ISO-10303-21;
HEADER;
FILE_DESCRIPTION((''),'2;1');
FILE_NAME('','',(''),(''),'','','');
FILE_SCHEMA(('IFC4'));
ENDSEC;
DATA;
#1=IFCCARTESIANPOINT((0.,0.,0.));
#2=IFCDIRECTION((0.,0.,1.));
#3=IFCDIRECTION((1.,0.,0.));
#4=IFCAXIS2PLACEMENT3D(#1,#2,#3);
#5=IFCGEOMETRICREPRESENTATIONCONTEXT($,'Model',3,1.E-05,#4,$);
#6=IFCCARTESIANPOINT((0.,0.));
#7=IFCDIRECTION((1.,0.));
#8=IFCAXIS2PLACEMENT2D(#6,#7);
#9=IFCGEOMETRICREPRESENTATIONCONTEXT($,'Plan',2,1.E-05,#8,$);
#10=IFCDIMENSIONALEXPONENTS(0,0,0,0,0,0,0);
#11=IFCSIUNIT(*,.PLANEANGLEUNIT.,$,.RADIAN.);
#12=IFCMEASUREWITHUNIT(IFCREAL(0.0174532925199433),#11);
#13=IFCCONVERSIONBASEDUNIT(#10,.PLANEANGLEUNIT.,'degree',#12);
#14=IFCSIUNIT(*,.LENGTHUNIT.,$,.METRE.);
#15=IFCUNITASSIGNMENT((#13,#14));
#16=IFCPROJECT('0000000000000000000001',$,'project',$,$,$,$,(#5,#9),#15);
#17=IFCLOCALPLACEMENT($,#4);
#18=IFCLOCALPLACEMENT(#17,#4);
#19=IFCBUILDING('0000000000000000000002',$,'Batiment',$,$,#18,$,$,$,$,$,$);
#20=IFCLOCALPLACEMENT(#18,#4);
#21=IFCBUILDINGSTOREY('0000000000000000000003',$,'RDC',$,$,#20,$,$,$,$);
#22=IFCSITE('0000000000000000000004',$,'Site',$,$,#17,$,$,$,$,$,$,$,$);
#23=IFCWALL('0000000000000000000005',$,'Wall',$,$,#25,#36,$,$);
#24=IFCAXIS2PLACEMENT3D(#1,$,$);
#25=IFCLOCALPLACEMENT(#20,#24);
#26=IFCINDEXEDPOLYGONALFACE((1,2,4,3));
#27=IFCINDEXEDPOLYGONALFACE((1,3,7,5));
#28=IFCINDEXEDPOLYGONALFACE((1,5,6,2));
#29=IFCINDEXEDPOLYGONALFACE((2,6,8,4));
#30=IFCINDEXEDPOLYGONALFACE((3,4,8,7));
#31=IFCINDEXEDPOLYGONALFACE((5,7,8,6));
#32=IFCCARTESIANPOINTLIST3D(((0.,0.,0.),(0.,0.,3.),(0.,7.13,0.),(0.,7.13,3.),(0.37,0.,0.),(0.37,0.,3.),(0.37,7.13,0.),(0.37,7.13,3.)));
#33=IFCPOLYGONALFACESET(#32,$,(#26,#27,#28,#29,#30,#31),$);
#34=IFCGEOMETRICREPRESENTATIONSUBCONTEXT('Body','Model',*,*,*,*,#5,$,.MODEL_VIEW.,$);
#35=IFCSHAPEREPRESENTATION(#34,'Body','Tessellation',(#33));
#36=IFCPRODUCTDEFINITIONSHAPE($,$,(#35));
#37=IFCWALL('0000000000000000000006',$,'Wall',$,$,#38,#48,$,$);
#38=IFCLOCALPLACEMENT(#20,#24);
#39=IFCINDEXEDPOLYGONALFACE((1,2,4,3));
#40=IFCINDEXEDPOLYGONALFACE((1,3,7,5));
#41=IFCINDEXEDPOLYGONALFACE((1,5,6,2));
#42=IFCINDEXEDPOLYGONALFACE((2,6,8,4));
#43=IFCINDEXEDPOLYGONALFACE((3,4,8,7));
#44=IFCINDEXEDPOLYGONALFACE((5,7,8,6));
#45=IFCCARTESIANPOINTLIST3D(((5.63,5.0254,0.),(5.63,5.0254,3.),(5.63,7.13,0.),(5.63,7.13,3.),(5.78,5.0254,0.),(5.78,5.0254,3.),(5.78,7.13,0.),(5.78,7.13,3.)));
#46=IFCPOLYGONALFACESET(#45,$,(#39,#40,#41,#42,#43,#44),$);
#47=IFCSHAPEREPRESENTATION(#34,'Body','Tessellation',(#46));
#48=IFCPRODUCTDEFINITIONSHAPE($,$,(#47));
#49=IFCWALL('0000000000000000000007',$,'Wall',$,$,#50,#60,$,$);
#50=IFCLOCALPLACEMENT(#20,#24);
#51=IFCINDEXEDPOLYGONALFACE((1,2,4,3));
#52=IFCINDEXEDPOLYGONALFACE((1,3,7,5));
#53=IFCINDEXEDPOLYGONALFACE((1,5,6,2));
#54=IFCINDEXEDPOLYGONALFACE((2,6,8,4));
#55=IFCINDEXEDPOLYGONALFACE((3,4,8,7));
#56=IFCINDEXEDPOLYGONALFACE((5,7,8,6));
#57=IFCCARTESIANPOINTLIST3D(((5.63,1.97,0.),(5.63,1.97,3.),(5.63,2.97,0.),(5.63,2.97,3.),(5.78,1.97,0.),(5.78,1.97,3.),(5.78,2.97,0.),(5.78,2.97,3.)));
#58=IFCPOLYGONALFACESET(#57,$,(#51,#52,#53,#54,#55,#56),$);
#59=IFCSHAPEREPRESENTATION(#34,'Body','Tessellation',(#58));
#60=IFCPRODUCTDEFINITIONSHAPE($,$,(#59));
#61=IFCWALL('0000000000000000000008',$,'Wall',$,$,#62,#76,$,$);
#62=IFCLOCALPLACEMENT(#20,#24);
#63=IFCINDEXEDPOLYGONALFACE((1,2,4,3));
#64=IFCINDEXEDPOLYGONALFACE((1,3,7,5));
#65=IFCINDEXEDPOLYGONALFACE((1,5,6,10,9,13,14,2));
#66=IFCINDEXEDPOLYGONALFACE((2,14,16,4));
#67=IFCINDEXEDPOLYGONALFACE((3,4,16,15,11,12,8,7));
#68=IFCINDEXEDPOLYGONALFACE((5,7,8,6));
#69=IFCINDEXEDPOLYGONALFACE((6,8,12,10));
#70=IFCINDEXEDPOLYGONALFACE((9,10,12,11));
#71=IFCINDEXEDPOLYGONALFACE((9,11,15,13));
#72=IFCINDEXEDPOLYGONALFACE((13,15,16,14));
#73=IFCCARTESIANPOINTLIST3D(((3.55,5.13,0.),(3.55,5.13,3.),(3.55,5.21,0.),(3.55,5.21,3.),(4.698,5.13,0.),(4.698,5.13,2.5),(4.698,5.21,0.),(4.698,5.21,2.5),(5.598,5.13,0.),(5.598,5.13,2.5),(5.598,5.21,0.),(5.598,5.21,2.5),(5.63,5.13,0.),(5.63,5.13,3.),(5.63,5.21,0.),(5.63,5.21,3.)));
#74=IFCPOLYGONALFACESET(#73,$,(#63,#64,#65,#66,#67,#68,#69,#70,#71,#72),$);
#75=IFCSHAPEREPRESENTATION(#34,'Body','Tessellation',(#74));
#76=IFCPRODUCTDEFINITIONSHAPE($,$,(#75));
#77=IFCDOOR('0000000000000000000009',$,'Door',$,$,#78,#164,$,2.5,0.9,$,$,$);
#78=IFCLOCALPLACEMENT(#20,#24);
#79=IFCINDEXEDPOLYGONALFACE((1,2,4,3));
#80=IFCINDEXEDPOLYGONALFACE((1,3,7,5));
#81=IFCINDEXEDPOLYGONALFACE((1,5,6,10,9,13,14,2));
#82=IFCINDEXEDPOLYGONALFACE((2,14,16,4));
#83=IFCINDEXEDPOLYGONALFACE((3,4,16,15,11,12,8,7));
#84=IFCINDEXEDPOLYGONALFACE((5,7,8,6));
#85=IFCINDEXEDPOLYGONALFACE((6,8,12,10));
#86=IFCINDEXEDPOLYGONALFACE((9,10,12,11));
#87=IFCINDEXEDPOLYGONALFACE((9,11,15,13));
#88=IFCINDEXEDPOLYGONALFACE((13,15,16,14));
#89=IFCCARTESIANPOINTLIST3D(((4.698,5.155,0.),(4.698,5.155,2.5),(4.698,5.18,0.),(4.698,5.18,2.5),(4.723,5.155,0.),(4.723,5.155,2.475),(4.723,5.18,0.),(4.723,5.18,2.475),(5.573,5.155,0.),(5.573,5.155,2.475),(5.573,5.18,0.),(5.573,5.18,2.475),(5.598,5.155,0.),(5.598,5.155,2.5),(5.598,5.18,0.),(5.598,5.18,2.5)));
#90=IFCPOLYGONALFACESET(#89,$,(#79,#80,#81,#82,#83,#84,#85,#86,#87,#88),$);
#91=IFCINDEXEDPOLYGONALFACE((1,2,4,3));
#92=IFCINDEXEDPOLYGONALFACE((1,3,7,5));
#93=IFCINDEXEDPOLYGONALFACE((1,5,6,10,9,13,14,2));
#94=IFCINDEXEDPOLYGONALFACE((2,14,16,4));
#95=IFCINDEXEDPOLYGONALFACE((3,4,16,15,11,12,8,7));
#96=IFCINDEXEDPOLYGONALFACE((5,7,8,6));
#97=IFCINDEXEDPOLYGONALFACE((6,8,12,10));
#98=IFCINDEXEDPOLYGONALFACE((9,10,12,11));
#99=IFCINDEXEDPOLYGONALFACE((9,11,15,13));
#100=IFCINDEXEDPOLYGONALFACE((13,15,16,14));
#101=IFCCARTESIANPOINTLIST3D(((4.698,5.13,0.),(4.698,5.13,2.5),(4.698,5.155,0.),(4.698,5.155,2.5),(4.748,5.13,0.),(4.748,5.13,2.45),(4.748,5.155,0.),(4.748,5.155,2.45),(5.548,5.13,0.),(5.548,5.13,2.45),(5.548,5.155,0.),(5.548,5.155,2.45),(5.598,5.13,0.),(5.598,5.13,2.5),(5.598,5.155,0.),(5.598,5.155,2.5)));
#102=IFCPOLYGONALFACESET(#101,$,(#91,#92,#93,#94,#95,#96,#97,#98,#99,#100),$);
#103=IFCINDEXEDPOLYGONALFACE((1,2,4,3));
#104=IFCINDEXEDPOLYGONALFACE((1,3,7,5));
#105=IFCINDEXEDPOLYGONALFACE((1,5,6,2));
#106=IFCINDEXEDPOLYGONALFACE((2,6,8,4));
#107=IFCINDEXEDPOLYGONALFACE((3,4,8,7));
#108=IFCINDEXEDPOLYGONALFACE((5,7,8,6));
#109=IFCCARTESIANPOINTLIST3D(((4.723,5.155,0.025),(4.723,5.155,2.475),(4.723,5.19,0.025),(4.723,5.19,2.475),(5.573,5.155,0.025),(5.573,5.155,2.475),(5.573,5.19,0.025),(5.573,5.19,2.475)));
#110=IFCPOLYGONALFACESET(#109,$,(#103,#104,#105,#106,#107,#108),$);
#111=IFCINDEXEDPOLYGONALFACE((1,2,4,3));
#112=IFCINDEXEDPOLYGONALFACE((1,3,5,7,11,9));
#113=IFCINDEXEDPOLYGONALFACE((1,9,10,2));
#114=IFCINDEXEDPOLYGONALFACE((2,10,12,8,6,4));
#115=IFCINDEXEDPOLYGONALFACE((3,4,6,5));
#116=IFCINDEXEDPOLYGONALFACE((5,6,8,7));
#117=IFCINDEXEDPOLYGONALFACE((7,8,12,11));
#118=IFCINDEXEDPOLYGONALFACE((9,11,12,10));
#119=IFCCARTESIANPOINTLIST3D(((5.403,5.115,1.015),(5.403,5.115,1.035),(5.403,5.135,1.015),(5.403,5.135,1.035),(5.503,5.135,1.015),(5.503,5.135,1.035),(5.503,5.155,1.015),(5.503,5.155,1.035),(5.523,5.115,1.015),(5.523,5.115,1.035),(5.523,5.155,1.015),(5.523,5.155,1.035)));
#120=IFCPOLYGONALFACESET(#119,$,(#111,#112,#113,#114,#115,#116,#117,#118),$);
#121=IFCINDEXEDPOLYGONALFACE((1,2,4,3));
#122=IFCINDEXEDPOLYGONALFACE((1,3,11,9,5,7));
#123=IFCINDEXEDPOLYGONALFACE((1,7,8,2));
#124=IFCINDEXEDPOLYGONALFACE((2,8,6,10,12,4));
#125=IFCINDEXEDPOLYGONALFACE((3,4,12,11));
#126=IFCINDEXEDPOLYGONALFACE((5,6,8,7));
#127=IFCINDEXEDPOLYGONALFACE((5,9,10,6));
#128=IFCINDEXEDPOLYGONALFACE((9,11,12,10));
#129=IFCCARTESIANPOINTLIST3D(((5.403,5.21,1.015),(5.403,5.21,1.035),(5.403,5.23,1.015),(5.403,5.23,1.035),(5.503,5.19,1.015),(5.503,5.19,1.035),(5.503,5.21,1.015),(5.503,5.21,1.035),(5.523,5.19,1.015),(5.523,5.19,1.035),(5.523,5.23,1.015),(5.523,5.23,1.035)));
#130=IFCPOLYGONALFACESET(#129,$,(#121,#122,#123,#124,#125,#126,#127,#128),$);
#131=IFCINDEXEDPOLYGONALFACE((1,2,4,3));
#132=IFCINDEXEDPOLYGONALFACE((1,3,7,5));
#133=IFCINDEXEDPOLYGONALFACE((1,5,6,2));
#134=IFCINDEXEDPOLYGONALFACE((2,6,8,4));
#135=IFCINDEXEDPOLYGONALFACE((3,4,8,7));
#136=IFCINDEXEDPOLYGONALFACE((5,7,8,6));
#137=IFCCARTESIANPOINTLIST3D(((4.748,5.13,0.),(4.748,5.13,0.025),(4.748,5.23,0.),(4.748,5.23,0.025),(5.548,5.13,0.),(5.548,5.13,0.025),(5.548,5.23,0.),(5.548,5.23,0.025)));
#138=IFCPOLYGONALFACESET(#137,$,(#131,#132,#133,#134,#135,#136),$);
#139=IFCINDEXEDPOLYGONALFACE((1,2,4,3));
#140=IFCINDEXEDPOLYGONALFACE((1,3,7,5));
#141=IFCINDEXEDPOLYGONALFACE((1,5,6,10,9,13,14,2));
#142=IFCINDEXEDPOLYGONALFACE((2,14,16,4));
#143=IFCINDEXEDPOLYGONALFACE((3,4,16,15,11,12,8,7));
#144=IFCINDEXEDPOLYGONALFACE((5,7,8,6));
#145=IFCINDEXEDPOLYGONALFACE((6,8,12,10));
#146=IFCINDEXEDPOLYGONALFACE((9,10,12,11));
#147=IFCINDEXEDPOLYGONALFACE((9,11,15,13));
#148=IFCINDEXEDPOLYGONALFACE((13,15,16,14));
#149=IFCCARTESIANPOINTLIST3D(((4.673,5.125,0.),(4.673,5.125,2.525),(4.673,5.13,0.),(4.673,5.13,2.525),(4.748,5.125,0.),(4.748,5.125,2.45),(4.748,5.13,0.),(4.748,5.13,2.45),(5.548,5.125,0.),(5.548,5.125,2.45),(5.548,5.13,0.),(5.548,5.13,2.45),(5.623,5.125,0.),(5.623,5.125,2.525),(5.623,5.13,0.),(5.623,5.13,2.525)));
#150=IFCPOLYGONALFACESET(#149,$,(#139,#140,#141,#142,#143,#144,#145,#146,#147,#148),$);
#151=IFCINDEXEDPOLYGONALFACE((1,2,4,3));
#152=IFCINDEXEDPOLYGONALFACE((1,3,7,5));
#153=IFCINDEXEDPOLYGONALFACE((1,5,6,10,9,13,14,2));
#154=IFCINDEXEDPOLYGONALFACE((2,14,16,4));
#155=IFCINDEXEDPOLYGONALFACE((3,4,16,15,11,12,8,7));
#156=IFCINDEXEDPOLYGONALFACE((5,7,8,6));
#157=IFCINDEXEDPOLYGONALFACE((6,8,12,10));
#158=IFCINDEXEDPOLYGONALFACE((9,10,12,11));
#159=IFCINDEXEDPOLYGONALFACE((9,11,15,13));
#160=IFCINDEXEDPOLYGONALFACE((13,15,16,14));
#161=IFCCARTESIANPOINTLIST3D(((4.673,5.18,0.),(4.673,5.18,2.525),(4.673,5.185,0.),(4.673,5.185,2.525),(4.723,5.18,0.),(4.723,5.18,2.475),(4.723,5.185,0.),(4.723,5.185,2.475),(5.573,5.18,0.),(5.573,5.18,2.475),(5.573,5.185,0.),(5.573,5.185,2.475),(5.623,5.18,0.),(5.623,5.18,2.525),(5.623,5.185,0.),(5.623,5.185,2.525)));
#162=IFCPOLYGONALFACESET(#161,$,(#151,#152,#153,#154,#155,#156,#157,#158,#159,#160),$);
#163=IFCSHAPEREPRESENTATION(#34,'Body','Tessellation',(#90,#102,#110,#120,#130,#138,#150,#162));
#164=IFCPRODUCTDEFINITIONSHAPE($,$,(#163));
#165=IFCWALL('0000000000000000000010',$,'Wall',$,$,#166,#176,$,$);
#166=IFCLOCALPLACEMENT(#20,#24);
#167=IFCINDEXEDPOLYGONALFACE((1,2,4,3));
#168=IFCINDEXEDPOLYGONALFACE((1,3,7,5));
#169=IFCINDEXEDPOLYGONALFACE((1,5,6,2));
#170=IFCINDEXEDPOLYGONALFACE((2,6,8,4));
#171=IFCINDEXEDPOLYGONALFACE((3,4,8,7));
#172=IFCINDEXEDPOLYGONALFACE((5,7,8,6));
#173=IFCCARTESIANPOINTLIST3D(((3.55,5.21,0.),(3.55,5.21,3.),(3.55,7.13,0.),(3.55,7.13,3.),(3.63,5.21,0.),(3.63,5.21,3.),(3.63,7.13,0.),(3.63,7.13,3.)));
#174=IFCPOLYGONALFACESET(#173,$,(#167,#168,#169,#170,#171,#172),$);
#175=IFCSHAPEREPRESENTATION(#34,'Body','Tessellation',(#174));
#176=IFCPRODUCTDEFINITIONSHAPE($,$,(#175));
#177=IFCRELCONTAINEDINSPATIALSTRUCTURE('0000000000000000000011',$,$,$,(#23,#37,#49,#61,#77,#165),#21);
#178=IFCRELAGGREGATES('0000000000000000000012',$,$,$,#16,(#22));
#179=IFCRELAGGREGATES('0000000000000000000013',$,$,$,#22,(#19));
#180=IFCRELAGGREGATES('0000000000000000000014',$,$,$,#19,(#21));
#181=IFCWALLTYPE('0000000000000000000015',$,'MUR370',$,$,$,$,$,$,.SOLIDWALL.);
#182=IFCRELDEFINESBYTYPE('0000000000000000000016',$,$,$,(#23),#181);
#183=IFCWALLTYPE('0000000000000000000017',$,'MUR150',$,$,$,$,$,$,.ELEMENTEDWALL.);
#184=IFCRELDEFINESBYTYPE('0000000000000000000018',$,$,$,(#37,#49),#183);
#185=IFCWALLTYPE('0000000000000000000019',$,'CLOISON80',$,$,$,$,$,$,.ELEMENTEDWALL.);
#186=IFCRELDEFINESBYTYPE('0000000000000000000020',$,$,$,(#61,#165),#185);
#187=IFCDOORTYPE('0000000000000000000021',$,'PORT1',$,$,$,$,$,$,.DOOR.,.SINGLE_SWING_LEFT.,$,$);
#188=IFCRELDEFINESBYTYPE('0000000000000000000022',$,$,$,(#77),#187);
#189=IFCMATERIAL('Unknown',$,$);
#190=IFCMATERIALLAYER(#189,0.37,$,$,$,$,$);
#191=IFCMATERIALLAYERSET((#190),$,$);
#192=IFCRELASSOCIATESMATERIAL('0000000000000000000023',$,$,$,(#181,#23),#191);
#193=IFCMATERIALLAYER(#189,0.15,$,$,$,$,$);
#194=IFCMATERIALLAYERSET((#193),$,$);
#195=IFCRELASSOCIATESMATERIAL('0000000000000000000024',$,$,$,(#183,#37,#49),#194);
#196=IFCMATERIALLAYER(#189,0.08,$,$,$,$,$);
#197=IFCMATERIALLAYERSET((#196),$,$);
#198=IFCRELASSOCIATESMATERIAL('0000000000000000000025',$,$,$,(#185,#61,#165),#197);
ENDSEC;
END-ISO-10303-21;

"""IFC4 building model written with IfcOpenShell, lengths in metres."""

from ifc_helpers import new_model, entity, si_unit, converted_unit, frame, origin_with_axes, origin_2d_with_axis, place, context, subcontext, project, spatial, line, indexed_curve, outline, extrude, shape, source, transform, mapped, material, layer, layer_set, layer_usage, type_object, type_shapes, element, fill, save


model = new_model("IFC4")

# Units and contexts
model_context = context("Model", 3, precision=1e-05, world=origin_with_axes())
plan_context = context("Plan", 2, precision=1e-05, world=origin_2d_with_axis())
body_context_1 = subcontext(model_context, "Body", "Model", "MODEL_VIEW")
body_context_2 = subcontext(plan_context, "Body", "Plan", "PLAN_VIEW")
ifc_project = project(units=[converted_unit("PLANEANGLEUNIT", "degree", entity("IfcReal", 0.0174532925199433), si_unit("PLANEANGLEUNIT", "RADIAN"), dimensions=[0, 0, 0, 0, 0, 0, 0]), si_unit("LENGTHUNIT", "METRE")], contexts=[model_context, plan_context])

# Site, building, storey
site_placement = place(None, origin_with_axes())
site = spatial("IfcSite", under=ifc_project, at=site_placement, Name="Site")
building_placement = place(site_placement, origin_with_axes())
building = spatial("IfcBuilding", under=site, at=building_placement, Name="Batiment")
storey_placement = place(building_placement, origin_with_axes())
storey = spatial("IfcBuildingStorey", under=building, at=storey_placement, Name="RDC")

# Shared definitions
ifc_material = material(Name="Unknown")

# Shared definitions
ifc_layer_1 = layer(ifc_material, 0.37)
ifc_layer_set_1 = layer_set([ifc_layer_1])
wall_type_1 = type_object("IfcWallType", Name="MUR370", PredefinedType="SOLIDWALL", material=ifc_layer_set_1)

# Shared definitions
shared_shape_1 = source(origin_with_axes(), body_context_1, "Body", "SweptSolid", [
    extrude(outline(indexed_curve([(0.0, 0.0), (0.9, 0.0), (0.9, 2.5), (0.0, 2.5)], segments=[line(1, 2, 3, 4, 1)])), frame((0.0, -0.6, 0.0), z_axis=(0.0, -1.0, 0.0), x_axis=(1.0, 0.0, 0.0)), (0.0, 0.0, -1.0), 1.2),
])
door_type_1 = type_object("IfcDoorType", Name="PORT1", OperationType="SINGLE_SWING_LEFT", PredefinedType="DOOR")
shared_shape_2 = source(origin_with_axes(), body_context_1, "Body", "SweptSolid", [
    extrude(outline(indexed_curve([(0.0, 0.0), (0.0, 2.5), (0.9, 2.5), (0.9, 0.0), (0.875, 0.0), (0.875, 2.475), (0.025, 2.475), (0.025, 0.0)], segments=[line(1, 2, 3, 4, 5, 6, 7, 8, 1)])), frame((0.0, 0.025, 0.0), z_axis=(0.0, -1.0, 0.0), x_axis=(1.0, 0.0, 0.0)), (0.0, 0.0, -1.0), 0.025),
    extrude(outline(indexed_curve([(0.0, 0.0), (0.0, 2.5), (0.9, 2.5), (0.9, 0.0), (0.85, 0.0), (0.85, 2.45), (0.05, 2.45), (0.05, 0.0)], segments=[line(1, 2, 3, 4, 5, 6, 7, 8, 1)])), frame((0.0, 0.0, 0.0), z_axis=(0.0, -1.0, 0.0), x_axis=(1.0, 0.0, 0.0)), (0.0, 0.0, -1.0), 0.025),
    extrude(outline(indexed_curve([(0.0, 0.0), (0.85, 0.0), (0.85, 0.035), (0.0, 0.035)], segments=[line(1, 2, 3, 4, 1)])), frame((0.025, 0.025, 0.025), z_axis=(0.0, 0.0, 1.0), x_axis=(1.0, 0.0, 0.0)), (0.0, 0.0, 1.0), 2.45),
    extrude(outline(indexed_curve([(0.0, 0.0), (0.0, -0.04), (-0.12, -0.04), (-0.12, -0.02), (-0.02, -0.02), (-0.02, 0.0)], segments=[line(1, 2, 3, 4, 5, 6, 1)])), frame((0.825, 0.025, 1.015), z_axis=(0.0, 0.0, 1.0), x_axis=(1.0, 0.0, 0.0)), (0.0, 0.0, 1.0), 0.02),
    extrude(outline(indexed_curve([(0.0, 0.0), (0.0, 0.04), (-0.12, 0.04), (-0.12, 0.02), (-0.02, 0.02), (-0.02, 0.0)], segments=[line(1, 2, 3, 4, 5, 6, 1)])), frame((0.825, 0.06, 1.015), z_axis=(0.0, 0.0, 1.0), x_axis=(1.0, 0.0, 0.0)), (0.0, 0.0, 1.0), 0.02),
    extrude(outline(indexed_curve([(0.0, 0.0), (0.8, 0.0), (0.8, 0.1), (0.0, 0.1)], segments=[line(1, 2, 3, 4, 1)])), frame((0.05, 0.0, 0.0), z_axis=(0.0, 0.0, 1.0), x_axis=(1.0, 0.0, 0.0)), (0.0, 0.0, 1.0), 0.025),
    extrude(outline(indexed_curve([(0.0, 0.0), (0.0, 2.525), (0.95, 2.525), (0.95, 0.0), (0.875, 0.0), (0.875, 2.45), (0.075, 2.45), (0.075, 0.0)], segments=[line(1, 2, 3, 4, 5, 6, 7, 8, 1)])), frame((-0.025, -0.005, 0.0), z_axis=(0.0, -1.0, 0.0), x_axis=(1.0, 0.0, 0.0)), (0.0, 0.0, -1.0), 0.005),
    extrude(outline(indexed_curve([(0.0, 0.0), (0.0, 2.525), (0.95, 2.525), (0.95, 0.0), (0.9, 0.0), (0.9, 2.475), (0.05, 2.475), (0.05, 0.0)], segments=[line(1, 2, 3, 4, 5, 6, 7, 8, 1)])), frame((-0.025, 0.05, 0.0), z_axis=(0.0, -1.0, 0.0), x_axis=(1.0, 0.0, 0.0)), (0.0, 0.0, -1.0), 0.005),
])
shared_shape_3 = source(origin_with_axes(), body_context_2, "Body", "Curve2D", [
    entity("IfcIndexedPolyCurve", entity("IfcCartesianPointList2D", [[0.0, 0.0], [0.0, 0.05], [0.025, 0.05], [0.025, 0.025], [0.05, 0.025], [0.05, 0.0]]), [entity("IfcLineIndex", [1, 2, 3, 4, 5, 6, 1])]),
    entity("IfcIndexedPolyCurve", entity("IfcCartesianPointList2D", [[0.9, 0.0], [0.9, 0.05], [0.875, 0.05], [0.875, 0.025], [0.85, 0.025], [0.85, 0.0]]), [entity("IfcLineIndex", [1, 2, 3, 4, 5, 6, 1])]),
    entity("IfcTrimmedCurve", entity("IfcEllipse", entity("IfcAxis2Placement2D", entity("IfcCartesianPoint", [0.06, 0.05]), entity("IfcDirection", [1.0, 0.0])), 0.815, 0.85), [entity("IfcCartesianPoint", [0.875, 0.05])], [entity("IfcCartesianPoint", [0.06, 0.9])], True, "CARTESIAN"),
    entity("IfcIndexedPolyCurve", entity("IfcCartesianPointList2D", [[0.025, 0.05], [0.06, 0.05], [0.06, 0.9], [0.025, 0.9]]), [entity("IfcLineIndex", [1, 2, 3, 4, 1])]),
])
type_shapes(door_type_1, [shared_shape_2, shared_shape_3])

# Walls
ifc_layer_usage_1 = layer_usage(ifc_layer_set_1, "AXIS2", "POSITIVE", 0.0)
wall_1_placement = place(storey_placement, frame((0.0, 7.13, 0.0), z_axis=(0.0, 0.0, 1.0), x_axis=(-0.000001, -1.0, 0.0)))
element("IfcWall", 1, at=wall_1_placement, inside=storey, type_object=wall_type_1, material=ifc_layer_usage_1, Name="Wall", context=body_context_1, shape_type="SweptSolid", body=[
    extrude(outline(indexed_curve([(0.0, 0.0), (0.0, 0.37), (7.13, 0.37), (7.13, 0.0), (0.0, 0.0)], self_intersect=False)), origin_with_axes(), (0.0, 0.0, 1.0), 3.0),
])
ifc_layer_2 = layer(ifc_material, 0.15)
ifc_layer_set_2 = layer_set([ifc_layer_2])
ifc_layer_usage_2 = layer_usage(ifc_layer_set_2, "AXIS2", "POSITIVE", 0.0)
wall_type_2 = type_object("IfcWallType", Name="MUR150", PredefinedType="ELEMENTEDWALL", material=ifc_layer_set_2)
wall_2_placement = place(storey_placement, frame((5.63, 7.13, 0.0), z_axis=(0.0, 0.0, 1.0), x_axis=(0.0, -1.0, 0.0)))
element("IfcWall", 2, at=wall_2_placement, inside=storey, type_object=wall_type_2, material=ifc_layer_usage_2, Name="Wall", context=body_context_1, shape_type="SweptSolid", body=[
    extrude(outline(indexed_curve([(0.0, 0.0), (0.0, 0.15), (2.1046, 0.15), (2.1046, 0.0), (0.0, 0.0)], self_intersect=False)), origin_with_axes(), (0.0, 0.0, 1.0), 3.0),
])
ifc_layer_usage_3 = layer_usage(ifc_layer_set_2, "AXIS2", "POSITIVE", 0.0)
wall_3_placement = place(storey_placement, frame((5.63, 2.97, 0.0), z_axis=(0.0, 0.0, 1.0), x_axis=(0.0, -1.0, 0.0)))
element("IfcWall", 3, at=wall_3_placement, inside=storey, type_object=wall_type_2, material=ifc_layer_usage_3, Name="Wall", context=body_context_1, shape_type="SweptSolid", body=[
    extrude(outline(indexed_curve([(0.0, 0.0), (0.0, 0.15), (1.0, 0.15), (1.0, 0.0), (0.0, 0.0)], self_intersect=False)), origin_with_axes(), (0.0, 0.0, 1.0), 3.0),
])

# Wall, opening, door
ifc_layer_3 = layer(ifc_material, 0.08)
ifc_layer_set_3 = layer_set([ifc_layer_3])
ifc_layer_usage_4 = layer_usage(ifc_layer_set_3, "AXIS2", "POSITIVE", 0.0)
wall_type_3 = type_object("IfcWallType", Name="CLOISON80", PredefinedType="ELEMENTEDWALL", material=ifc_layer_set_3)
wall_4_placement = place(storey_placement, frame((3.55, 5.13, 0.0), z_axis=(0.0, 0.0, 1.0), x_axis=(1.0, 0.0, 0.0)))
wall_4 = element("IfcWall", 4, at=wall_4_placement, inside=storey, type_object=wall_type_3, material=ifc_layer_usage_4, Name="Wall", context=body_context_1, shape_type="SweptSolid", body=[
    extrude(outline(indexed_curve([(0.0, 0.0), (0.0, 0.08), (2.08, 0.08), (2.08, 0.0), (0.0, 0.0)], self_intersect=False)), origin_with_axes(), (0.0, 0.0, 1.0), 3.0),
])
opening_1_placement = place(wall_4_placement, frame((1.148, 0.0, 0.0), z_axis=(0.0, 0.0, 1.0), x_axis=(1.0, 0.0, 0.0)))
opening_1 = element("IfcOpeningElement", 5, at=opening_1_placement, cuts=wall_4, PredefinedType="OPENING", context=body_context_1, shape_type="MappedRepresentation", body=[
    mapped(shared_shape_1, transform((0.0, 0.0, 0.0), x_axis=(1.0, 0.0, 0.0), y_axis=(0.0, 1.0, 0.0), z_axis=(0.0, 0.0, 1.0), scale=1.0)),
])
door_1_placement = place(opening_1_placement, frame((0.0, 0.0, 0.0), z_axis=(0.0, 0.0, 1.0), x_axis=(1.0, 0.0, 0.0)))
door_1 = element("IfcDoor", 6, at=door_1_placement, inside=storey, type_object=door_type_1, Name="Door", OverallHeight=2.5, OverallWidth=0.9, shapes=[
    shape(body_context_1, "Body", "MappedRepresentation", [mapped(shared_shape_2, transform((0.0, 0.0, 0.0), x_axis=(1.0, 0.0, 0.0), y_axis=(0.0, 1.0, 0.0), z_axis=(0.0, 0.0, 1.0), scale=1.0))]),
    shape(body_context_2, "Body", "MappedRepresentation", [mapped(shared_shape_3, transform((0.0, 0.0, 0.0), x_axis=(1.0, 0.0, 0.0), y_axis=(0.0, 1.0, 0.0), z_axis=(0.0, 0.0, 1.0), scale=1.0))]),
])
fill(opening_1, door_1)

# Wall
ifc_layer_usage_5 = layer_usage(ifc_layer_set_3, "AXIS2", "POSITIVE", 0.0)
wall_5_placement = place(storey_placement, frame((3.63, 5.21, 0.0), z_axis=(0.0, 0.0, 1.0), x_axis=(0.0, 1.0, 0.0)))
element("IfcWall", 7, at=wall_5_placement, inside=storey, type_object=wall_type_3, material=ifc_layer_usage_5, Name="Wall", context=body_context_1, shape_type="SweptSolid", body=[
    extrude(outline(indexed_curve([(0.0, 0.0), (0.0, 0.08), (1.92, 0.08), (1.92, 0.0), (0.0, 0.0)], self_intersect=False)), origin_with_axes(), (0.0, 0.0, 1.0), 3.0),
])

save(model, "model.ifc")
